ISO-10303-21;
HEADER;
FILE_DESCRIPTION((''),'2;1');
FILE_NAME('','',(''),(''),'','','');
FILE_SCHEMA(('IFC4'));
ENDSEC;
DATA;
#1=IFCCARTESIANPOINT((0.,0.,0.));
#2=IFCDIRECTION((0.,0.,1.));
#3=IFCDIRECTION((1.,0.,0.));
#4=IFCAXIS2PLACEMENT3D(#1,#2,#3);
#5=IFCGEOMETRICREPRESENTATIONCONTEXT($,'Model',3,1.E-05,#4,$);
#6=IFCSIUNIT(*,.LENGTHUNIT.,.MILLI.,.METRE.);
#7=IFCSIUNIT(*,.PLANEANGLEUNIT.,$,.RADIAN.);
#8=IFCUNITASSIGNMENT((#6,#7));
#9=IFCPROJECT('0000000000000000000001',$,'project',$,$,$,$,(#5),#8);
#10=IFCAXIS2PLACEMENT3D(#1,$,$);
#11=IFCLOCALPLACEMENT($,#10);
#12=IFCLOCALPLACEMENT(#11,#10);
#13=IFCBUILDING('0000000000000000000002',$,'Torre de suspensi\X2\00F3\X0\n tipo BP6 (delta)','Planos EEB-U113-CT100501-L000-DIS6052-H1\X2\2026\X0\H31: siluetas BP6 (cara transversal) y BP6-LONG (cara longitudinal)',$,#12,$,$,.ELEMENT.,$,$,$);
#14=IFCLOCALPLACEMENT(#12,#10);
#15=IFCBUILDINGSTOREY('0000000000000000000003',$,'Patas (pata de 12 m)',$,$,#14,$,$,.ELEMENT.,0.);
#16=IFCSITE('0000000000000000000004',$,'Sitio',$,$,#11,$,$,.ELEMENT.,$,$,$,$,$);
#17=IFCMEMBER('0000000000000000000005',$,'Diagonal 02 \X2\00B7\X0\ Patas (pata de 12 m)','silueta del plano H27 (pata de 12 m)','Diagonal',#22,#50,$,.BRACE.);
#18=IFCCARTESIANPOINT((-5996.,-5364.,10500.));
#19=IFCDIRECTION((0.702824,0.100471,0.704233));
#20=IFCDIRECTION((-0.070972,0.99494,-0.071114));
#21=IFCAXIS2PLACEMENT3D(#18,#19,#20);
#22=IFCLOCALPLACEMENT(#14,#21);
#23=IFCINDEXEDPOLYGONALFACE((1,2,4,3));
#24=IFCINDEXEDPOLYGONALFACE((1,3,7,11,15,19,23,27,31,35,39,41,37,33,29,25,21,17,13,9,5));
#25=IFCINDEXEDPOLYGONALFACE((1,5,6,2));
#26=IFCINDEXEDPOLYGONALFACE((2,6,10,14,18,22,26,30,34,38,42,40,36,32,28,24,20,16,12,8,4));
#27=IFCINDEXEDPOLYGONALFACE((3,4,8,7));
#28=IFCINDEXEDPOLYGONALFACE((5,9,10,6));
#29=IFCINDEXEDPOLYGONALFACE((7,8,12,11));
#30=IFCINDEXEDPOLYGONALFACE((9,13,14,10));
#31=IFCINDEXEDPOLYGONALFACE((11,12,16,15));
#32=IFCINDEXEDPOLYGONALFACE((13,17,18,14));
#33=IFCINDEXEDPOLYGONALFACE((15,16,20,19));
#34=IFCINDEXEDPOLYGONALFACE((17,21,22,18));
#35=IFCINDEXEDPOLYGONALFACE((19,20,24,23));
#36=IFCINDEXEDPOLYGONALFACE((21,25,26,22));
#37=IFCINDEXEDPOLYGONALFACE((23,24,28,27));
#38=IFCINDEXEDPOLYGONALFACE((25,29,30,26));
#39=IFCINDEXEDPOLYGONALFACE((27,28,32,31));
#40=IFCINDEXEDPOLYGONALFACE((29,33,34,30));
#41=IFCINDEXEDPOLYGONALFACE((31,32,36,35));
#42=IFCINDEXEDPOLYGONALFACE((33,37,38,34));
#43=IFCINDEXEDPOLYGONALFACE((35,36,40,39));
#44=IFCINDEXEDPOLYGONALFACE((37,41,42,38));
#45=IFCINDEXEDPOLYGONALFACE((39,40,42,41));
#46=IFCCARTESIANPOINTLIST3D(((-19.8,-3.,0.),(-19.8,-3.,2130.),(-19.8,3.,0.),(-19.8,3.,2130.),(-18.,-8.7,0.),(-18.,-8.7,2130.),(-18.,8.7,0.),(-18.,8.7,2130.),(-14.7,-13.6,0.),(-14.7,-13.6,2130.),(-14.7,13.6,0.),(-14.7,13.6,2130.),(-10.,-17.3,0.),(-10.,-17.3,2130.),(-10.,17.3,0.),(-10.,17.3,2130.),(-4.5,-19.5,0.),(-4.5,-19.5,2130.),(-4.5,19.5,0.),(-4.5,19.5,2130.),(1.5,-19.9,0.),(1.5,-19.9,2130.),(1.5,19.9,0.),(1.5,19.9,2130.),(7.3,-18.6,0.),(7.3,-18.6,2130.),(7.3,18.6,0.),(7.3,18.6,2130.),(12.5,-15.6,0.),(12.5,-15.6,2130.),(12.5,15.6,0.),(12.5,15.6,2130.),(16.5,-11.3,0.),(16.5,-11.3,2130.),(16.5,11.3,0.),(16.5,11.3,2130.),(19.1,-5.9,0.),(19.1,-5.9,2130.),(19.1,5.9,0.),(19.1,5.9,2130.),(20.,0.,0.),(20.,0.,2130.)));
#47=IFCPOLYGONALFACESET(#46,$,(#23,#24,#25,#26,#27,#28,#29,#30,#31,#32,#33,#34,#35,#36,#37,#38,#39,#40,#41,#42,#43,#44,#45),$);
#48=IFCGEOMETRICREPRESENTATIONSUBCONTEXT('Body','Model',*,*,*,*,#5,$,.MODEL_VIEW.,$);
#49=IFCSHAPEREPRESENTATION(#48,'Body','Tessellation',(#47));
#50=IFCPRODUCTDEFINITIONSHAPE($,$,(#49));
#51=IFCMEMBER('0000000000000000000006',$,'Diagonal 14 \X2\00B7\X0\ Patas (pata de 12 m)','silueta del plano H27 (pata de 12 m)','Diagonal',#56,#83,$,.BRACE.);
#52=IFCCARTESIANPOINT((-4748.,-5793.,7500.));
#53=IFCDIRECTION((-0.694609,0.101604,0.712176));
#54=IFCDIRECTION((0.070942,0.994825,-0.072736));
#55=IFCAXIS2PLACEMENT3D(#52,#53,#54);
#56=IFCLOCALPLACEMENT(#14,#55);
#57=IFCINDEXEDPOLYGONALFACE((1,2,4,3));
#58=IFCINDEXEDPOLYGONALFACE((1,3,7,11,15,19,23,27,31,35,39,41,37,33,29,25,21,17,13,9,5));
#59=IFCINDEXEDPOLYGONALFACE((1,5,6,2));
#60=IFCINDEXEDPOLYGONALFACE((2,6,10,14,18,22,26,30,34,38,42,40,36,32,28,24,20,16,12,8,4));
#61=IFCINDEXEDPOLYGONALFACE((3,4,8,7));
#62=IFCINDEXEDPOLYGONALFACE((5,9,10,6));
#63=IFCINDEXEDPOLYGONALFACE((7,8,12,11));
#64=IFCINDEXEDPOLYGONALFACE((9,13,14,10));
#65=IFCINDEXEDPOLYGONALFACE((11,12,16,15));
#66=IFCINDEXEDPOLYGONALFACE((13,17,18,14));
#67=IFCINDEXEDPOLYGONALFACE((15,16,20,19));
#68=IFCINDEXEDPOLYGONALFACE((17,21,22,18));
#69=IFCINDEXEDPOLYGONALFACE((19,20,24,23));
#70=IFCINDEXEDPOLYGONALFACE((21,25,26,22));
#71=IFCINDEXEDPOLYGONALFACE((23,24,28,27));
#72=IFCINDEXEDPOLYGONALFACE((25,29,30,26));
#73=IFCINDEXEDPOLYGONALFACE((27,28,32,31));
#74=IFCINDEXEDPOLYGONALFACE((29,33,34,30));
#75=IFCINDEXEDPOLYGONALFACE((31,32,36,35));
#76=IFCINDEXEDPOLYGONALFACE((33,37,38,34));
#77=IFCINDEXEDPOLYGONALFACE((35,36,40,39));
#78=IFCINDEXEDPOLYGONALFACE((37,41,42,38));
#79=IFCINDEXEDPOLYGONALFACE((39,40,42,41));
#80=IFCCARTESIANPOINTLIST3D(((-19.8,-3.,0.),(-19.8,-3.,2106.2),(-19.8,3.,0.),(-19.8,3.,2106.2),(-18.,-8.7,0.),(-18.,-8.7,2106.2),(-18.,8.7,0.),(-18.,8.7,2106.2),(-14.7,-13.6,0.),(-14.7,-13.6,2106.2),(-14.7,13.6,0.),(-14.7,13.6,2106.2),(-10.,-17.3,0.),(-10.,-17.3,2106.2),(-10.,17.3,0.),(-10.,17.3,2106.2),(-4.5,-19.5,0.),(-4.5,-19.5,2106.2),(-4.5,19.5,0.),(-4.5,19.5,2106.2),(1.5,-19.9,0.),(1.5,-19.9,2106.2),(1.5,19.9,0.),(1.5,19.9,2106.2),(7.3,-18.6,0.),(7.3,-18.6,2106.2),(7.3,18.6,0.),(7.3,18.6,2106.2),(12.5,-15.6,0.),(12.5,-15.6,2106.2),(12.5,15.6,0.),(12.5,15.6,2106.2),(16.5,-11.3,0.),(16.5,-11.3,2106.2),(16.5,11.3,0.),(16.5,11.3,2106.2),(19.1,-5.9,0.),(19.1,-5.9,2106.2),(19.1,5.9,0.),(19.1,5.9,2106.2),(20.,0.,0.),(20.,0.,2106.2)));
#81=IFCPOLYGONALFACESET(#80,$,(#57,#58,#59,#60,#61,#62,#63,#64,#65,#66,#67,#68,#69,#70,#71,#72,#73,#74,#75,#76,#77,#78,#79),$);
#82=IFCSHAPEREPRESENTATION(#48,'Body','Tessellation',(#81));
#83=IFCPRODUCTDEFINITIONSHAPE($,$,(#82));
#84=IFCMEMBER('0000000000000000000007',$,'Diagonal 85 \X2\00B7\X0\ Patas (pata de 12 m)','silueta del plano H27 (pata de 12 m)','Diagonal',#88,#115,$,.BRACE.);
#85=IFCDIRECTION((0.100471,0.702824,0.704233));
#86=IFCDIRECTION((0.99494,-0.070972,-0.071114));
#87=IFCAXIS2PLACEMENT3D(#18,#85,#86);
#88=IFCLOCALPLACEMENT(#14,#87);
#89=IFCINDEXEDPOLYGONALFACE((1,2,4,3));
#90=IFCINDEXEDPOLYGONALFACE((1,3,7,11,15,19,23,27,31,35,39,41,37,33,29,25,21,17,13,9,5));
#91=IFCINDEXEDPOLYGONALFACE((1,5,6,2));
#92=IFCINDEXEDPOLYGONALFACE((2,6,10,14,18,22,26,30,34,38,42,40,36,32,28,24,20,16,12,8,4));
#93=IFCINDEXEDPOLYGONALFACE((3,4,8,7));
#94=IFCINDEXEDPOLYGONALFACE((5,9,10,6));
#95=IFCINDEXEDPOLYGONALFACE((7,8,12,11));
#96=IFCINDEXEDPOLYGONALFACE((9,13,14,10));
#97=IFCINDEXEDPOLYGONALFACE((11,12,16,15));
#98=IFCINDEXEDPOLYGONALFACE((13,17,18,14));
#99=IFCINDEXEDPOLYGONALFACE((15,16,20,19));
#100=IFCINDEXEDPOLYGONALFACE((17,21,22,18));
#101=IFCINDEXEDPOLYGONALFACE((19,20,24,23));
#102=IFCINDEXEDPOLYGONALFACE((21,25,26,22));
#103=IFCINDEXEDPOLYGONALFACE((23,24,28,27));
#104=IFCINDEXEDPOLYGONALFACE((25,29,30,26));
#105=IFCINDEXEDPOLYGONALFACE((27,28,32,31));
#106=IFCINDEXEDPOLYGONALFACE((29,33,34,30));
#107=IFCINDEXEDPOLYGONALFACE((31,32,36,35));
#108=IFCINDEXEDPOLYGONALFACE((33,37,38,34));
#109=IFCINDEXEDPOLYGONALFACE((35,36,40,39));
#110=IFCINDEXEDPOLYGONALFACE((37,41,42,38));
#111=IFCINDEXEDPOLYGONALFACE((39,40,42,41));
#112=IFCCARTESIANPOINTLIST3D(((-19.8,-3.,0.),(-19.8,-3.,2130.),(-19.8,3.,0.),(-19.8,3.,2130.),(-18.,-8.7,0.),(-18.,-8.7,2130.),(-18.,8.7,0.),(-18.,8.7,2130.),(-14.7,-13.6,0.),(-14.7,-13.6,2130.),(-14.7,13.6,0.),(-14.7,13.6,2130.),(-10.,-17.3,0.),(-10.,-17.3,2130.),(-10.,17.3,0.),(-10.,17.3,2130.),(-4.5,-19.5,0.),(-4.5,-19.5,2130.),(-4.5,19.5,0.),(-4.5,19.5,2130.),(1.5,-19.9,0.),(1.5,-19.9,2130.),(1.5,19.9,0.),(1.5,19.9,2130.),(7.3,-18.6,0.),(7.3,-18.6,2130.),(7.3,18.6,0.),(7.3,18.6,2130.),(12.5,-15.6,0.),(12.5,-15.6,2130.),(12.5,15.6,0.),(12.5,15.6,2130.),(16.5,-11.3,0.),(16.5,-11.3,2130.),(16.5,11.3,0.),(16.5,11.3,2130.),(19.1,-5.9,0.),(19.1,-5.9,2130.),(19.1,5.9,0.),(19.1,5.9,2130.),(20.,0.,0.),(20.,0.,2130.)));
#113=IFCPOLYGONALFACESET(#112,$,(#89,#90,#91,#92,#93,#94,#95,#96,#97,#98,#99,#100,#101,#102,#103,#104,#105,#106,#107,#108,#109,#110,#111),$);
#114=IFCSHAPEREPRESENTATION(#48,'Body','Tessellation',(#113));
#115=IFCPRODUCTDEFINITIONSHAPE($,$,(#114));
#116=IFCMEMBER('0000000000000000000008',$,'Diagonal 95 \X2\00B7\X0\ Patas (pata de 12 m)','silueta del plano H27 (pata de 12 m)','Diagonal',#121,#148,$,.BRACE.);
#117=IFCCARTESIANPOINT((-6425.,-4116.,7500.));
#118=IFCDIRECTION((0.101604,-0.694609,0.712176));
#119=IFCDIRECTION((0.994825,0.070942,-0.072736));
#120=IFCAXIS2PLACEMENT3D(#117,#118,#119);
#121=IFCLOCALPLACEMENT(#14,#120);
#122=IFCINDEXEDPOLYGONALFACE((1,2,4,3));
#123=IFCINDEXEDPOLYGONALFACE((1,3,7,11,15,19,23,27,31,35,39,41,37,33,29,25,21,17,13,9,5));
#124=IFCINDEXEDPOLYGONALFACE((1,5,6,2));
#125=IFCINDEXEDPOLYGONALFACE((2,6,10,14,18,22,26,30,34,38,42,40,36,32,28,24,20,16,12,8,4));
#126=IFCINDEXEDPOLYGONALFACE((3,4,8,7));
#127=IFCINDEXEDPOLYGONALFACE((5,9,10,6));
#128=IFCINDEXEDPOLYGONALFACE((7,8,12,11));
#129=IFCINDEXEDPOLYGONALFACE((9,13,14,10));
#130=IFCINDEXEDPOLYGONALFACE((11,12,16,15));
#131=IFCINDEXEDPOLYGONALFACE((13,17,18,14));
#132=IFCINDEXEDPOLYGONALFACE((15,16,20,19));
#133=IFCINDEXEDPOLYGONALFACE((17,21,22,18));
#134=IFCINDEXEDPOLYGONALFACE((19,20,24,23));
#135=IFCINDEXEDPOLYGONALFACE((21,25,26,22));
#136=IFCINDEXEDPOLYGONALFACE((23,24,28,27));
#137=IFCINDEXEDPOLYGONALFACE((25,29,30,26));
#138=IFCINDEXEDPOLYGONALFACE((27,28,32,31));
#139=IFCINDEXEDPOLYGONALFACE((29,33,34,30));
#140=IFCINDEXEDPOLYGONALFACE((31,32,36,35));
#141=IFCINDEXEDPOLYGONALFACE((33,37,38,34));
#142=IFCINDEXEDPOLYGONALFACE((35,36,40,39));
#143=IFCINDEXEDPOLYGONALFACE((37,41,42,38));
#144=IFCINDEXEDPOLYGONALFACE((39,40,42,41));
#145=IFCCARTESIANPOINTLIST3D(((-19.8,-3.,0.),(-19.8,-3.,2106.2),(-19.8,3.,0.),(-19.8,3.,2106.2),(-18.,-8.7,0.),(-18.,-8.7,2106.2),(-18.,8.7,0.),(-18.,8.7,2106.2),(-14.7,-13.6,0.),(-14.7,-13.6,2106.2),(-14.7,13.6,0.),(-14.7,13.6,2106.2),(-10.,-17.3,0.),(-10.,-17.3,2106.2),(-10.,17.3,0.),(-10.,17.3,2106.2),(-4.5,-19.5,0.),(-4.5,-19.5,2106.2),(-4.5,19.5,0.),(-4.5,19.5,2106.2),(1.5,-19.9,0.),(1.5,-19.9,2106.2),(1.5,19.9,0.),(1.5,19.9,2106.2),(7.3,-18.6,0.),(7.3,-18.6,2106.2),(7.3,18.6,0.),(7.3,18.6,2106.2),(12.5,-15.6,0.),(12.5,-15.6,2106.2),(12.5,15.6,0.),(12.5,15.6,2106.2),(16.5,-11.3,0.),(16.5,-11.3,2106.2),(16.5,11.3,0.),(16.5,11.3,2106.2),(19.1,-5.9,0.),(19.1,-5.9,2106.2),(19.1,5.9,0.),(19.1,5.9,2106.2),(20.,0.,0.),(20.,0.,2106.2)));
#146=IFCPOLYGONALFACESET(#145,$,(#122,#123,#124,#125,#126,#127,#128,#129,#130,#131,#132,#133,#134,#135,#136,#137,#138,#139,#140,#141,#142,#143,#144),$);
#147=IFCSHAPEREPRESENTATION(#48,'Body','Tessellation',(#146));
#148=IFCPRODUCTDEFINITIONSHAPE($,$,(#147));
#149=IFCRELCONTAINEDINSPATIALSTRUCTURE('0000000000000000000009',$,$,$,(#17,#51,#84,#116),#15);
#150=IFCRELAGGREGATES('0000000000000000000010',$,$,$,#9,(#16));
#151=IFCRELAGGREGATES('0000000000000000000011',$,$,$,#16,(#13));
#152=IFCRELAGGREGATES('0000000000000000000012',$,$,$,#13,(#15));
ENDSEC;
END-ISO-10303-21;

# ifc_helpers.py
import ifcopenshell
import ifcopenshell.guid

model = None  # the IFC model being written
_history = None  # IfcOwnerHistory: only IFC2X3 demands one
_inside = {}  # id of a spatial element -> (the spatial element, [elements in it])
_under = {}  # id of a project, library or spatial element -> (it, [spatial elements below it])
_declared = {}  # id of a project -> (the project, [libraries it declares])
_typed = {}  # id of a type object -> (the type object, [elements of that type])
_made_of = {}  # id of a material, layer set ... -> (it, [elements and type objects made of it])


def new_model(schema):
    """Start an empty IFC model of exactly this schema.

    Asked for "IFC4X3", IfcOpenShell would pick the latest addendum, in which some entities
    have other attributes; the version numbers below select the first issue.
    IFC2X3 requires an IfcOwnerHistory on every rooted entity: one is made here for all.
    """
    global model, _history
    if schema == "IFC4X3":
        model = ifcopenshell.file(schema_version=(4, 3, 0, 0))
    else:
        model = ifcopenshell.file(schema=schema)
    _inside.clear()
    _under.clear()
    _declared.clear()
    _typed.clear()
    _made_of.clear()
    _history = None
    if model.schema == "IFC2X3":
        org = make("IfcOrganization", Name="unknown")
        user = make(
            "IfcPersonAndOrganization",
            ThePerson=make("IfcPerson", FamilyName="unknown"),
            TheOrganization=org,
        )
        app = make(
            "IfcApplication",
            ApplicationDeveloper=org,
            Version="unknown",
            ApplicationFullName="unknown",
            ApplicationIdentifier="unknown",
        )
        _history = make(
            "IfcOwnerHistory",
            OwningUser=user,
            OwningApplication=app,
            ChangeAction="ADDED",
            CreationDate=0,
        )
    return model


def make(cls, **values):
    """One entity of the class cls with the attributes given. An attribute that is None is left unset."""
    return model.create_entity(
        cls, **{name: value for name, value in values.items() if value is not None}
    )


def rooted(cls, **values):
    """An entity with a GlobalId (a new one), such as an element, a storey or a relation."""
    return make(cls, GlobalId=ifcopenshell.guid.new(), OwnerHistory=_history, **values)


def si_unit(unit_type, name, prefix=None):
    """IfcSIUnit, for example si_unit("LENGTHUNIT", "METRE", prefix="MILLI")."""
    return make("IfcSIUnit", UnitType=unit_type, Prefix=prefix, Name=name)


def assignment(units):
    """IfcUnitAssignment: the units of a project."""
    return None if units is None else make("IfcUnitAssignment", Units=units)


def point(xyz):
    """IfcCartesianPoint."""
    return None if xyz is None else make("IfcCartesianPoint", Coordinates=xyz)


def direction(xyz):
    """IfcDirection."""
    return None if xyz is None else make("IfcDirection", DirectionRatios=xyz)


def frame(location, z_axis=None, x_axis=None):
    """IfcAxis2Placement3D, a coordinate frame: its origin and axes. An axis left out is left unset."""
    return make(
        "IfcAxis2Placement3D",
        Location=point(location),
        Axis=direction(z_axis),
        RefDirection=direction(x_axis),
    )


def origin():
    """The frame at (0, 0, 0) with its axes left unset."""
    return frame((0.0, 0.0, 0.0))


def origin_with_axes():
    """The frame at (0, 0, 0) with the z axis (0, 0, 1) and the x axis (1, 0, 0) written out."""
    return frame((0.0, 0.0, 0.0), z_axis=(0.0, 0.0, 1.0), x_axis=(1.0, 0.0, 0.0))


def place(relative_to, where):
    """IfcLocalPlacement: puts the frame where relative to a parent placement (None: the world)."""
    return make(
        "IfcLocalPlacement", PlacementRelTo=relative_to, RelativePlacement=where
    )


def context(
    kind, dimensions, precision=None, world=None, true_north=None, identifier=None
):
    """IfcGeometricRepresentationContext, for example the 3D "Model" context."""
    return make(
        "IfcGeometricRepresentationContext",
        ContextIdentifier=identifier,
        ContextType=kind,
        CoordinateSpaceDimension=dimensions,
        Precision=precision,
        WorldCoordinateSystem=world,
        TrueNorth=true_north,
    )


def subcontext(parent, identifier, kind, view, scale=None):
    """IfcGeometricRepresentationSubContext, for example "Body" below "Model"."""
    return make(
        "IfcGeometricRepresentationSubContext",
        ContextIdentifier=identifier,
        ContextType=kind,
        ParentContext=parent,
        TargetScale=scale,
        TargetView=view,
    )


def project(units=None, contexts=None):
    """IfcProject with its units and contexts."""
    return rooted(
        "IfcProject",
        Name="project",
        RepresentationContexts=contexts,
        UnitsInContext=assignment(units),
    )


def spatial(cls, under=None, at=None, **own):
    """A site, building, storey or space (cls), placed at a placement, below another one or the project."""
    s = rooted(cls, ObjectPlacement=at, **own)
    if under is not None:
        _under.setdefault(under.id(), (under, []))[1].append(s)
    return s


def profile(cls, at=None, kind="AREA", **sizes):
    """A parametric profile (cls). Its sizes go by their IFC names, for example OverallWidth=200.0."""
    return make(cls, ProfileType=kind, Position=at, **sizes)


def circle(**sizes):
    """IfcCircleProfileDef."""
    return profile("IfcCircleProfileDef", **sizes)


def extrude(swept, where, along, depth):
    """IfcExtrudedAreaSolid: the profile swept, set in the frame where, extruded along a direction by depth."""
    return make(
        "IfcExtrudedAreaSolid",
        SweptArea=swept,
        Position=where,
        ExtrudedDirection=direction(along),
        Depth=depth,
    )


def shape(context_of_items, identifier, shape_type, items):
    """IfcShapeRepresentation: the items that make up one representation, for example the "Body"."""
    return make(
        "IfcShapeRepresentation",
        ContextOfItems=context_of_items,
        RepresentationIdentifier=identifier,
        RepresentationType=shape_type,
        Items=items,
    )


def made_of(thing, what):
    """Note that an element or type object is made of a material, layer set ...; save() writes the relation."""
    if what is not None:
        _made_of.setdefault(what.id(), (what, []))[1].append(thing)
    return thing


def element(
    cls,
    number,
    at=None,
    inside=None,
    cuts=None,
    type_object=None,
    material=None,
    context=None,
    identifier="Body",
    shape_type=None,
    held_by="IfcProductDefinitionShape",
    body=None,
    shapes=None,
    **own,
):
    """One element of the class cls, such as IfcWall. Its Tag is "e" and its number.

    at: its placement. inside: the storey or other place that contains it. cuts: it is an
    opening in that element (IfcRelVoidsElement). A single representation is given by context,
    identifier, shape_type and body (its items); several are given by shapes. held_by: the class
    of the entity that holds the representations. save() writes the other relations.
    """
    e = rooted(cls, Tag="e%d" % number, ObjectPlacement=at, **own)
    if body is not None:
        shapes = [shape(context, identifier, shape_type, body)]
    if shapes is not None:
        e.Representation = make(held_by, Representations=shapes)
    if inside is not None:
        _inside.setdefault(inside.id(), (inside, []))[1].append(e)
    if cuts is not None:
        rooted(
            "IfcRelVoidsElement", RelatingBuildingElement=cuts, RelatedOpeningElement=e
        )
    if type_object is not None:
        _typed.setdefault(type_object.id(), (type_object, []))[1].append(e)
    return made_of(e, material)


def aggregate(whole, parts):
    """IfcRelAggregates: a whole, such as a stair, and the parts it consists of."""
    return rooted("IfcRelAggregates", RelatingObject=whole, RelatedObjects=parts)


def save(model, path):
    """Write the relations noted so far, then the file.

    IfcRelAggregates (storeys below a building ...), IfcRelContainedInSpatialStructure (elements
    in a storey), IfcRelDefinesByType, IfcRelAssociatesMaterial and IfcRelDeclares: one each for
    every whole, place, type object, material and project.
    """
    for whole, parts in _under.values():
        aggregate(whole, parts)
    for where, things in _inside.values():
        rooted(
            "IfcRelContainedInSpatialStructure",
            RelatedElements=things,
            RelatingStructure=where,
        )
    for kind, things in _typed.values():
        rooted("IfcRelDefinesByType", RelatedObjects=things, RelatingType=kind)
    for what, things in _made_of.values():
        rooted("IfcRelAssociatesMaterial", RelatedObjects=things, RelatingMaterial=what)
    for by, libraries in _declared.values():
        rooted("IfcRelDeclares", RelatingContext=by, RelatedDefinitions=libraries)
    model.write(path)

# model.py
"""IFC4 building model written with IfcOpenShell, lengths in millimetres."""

from ifc_helpers import new_model, si_unit, frame, origin, origin_with_axes, place, context, subcontext, project, spatial, circle, extrude, element, save


model = new_model("IFC4")

# Units and contexts
model_context = context("Model", 3, precision=1e-05, world=origin_with_axes())
body_context = subcontext(model_context, "Body", "Model", "MODEL_VIEW")
ifc_project = project(units=[si_unit("LENGTHUNIT", "METRE", prefix="MILLI"), si_unit("PLANEANGLEUNIT", "RADIAN")], contexts=[model_context])

# Site, building, storey
site_placement = place(None, origin())
site = spatial("IfcSite", under=ifc_project, at=site_placement, Name="Sitio", CompositionType="ELEMENT")
building_placement = place(site_placement, origin())
building = spatial("IfcBuilding", under=site, at=building_placement, Name="Torre de suspensión tipo BP6 (delta)", Description="Planos EEB-U113-CT100501-L000-DIS6052-H1…H31: siluetas BP6 (cara transversal) y BP6-LONG (cara longitudinal)", CompositionType="ELEMENT")
storey_placement = place(building_placement, origin())
storey = spatial("IfcBuildingStorey", under=building, at=storey_placement, Name="Patas (pata de 12 m)", CompositionType="ELEMENT", Elevation=0.0)

# Members
member_1_placement = place(storey_placement, frame((-5996.0, -5364.0, 10500.0), z_axis=(0.702824, 0.100471, 0.704233), x_axis=(-0.070972, 0.99494, -0.071114)))
element("IfcMember", 1, at=member_1_placement, inside=storey, Name="Diagonal 02 · Patas (pata de 12 m)", Description="silueta del plano H27 (pata de 12 m)", ObjectType="Diagonal", PredefinedType="BRACE", context=body_context, shape_type="SweptSolid", body=[
    extrude(circle(Radius=20.0), None, (0.0, 0.0, 1.0), 2130.0),
])
member_2_placement = place(storey_placement, frame((-4748.0, -5793.0, 7500.0), z_axis=(-0.694609, 0.101604, 0.712176), x_axis=(0.070942, 0.994825, -0.072736)))
element("IfcMember", 2, at=member_2_placement, inside=storey, Name="Diagonal 14 · Patas (pata de 12 m)", Description="silueta del plano H27 (pata de 12 m)", ObjectType="Diagonal", PredefinedType="BRACE", context=body_context, shape_type="SweptSolid", body=[
    extrude(circle(Radius=20.0), None, (0.0, 0.0, 1.0), 2106.2),
])
member_3_placement = place(storey_placement, frame((-5996.0, -5364.0, 10500.0), z_axis=(0.100471, 0.702824, 0.704233), x_axis=(0.99494, -0.070972, -0.071114)))
element("IfcMember", 3, at=member_3_placement, inside=storey, Name="Diagonal 85 · Patas (pata de 12 m)", Description="silueta del plano H27 (pata de 12 m)", ObjectType="Diagonal", PredefinedType="BRACE", context=body_context, shape_type="SweptSolid", body=[
    extrude(circle(Radius=20.0), None, (0.0, 0.0, 1.0), 2130.0),
])
member_4_placement = place(storey_placement, frame((-6425.0, -4116.0, 7500.0), z_axis=(0.101604, -0.694609, 0.712176), x_axis=(0.994825, 0.070942, -0.072736)))
element("IfcMember", 4, at=member_4_placement, inside=storey, Name="Diagonal 95 · Patas (pata de 12 m)", Description="silueta del plano H27 (pata de 12 m)", ObjectType="Diagonal", PredefinedType="BRACE", context=body_context, shape_type="SweptSolid", body=[
    extrude(circle(Radius=20.0), None, (0.0, 0.0, 1.0), 2106.2),
])

save(model, "model.ifc")
